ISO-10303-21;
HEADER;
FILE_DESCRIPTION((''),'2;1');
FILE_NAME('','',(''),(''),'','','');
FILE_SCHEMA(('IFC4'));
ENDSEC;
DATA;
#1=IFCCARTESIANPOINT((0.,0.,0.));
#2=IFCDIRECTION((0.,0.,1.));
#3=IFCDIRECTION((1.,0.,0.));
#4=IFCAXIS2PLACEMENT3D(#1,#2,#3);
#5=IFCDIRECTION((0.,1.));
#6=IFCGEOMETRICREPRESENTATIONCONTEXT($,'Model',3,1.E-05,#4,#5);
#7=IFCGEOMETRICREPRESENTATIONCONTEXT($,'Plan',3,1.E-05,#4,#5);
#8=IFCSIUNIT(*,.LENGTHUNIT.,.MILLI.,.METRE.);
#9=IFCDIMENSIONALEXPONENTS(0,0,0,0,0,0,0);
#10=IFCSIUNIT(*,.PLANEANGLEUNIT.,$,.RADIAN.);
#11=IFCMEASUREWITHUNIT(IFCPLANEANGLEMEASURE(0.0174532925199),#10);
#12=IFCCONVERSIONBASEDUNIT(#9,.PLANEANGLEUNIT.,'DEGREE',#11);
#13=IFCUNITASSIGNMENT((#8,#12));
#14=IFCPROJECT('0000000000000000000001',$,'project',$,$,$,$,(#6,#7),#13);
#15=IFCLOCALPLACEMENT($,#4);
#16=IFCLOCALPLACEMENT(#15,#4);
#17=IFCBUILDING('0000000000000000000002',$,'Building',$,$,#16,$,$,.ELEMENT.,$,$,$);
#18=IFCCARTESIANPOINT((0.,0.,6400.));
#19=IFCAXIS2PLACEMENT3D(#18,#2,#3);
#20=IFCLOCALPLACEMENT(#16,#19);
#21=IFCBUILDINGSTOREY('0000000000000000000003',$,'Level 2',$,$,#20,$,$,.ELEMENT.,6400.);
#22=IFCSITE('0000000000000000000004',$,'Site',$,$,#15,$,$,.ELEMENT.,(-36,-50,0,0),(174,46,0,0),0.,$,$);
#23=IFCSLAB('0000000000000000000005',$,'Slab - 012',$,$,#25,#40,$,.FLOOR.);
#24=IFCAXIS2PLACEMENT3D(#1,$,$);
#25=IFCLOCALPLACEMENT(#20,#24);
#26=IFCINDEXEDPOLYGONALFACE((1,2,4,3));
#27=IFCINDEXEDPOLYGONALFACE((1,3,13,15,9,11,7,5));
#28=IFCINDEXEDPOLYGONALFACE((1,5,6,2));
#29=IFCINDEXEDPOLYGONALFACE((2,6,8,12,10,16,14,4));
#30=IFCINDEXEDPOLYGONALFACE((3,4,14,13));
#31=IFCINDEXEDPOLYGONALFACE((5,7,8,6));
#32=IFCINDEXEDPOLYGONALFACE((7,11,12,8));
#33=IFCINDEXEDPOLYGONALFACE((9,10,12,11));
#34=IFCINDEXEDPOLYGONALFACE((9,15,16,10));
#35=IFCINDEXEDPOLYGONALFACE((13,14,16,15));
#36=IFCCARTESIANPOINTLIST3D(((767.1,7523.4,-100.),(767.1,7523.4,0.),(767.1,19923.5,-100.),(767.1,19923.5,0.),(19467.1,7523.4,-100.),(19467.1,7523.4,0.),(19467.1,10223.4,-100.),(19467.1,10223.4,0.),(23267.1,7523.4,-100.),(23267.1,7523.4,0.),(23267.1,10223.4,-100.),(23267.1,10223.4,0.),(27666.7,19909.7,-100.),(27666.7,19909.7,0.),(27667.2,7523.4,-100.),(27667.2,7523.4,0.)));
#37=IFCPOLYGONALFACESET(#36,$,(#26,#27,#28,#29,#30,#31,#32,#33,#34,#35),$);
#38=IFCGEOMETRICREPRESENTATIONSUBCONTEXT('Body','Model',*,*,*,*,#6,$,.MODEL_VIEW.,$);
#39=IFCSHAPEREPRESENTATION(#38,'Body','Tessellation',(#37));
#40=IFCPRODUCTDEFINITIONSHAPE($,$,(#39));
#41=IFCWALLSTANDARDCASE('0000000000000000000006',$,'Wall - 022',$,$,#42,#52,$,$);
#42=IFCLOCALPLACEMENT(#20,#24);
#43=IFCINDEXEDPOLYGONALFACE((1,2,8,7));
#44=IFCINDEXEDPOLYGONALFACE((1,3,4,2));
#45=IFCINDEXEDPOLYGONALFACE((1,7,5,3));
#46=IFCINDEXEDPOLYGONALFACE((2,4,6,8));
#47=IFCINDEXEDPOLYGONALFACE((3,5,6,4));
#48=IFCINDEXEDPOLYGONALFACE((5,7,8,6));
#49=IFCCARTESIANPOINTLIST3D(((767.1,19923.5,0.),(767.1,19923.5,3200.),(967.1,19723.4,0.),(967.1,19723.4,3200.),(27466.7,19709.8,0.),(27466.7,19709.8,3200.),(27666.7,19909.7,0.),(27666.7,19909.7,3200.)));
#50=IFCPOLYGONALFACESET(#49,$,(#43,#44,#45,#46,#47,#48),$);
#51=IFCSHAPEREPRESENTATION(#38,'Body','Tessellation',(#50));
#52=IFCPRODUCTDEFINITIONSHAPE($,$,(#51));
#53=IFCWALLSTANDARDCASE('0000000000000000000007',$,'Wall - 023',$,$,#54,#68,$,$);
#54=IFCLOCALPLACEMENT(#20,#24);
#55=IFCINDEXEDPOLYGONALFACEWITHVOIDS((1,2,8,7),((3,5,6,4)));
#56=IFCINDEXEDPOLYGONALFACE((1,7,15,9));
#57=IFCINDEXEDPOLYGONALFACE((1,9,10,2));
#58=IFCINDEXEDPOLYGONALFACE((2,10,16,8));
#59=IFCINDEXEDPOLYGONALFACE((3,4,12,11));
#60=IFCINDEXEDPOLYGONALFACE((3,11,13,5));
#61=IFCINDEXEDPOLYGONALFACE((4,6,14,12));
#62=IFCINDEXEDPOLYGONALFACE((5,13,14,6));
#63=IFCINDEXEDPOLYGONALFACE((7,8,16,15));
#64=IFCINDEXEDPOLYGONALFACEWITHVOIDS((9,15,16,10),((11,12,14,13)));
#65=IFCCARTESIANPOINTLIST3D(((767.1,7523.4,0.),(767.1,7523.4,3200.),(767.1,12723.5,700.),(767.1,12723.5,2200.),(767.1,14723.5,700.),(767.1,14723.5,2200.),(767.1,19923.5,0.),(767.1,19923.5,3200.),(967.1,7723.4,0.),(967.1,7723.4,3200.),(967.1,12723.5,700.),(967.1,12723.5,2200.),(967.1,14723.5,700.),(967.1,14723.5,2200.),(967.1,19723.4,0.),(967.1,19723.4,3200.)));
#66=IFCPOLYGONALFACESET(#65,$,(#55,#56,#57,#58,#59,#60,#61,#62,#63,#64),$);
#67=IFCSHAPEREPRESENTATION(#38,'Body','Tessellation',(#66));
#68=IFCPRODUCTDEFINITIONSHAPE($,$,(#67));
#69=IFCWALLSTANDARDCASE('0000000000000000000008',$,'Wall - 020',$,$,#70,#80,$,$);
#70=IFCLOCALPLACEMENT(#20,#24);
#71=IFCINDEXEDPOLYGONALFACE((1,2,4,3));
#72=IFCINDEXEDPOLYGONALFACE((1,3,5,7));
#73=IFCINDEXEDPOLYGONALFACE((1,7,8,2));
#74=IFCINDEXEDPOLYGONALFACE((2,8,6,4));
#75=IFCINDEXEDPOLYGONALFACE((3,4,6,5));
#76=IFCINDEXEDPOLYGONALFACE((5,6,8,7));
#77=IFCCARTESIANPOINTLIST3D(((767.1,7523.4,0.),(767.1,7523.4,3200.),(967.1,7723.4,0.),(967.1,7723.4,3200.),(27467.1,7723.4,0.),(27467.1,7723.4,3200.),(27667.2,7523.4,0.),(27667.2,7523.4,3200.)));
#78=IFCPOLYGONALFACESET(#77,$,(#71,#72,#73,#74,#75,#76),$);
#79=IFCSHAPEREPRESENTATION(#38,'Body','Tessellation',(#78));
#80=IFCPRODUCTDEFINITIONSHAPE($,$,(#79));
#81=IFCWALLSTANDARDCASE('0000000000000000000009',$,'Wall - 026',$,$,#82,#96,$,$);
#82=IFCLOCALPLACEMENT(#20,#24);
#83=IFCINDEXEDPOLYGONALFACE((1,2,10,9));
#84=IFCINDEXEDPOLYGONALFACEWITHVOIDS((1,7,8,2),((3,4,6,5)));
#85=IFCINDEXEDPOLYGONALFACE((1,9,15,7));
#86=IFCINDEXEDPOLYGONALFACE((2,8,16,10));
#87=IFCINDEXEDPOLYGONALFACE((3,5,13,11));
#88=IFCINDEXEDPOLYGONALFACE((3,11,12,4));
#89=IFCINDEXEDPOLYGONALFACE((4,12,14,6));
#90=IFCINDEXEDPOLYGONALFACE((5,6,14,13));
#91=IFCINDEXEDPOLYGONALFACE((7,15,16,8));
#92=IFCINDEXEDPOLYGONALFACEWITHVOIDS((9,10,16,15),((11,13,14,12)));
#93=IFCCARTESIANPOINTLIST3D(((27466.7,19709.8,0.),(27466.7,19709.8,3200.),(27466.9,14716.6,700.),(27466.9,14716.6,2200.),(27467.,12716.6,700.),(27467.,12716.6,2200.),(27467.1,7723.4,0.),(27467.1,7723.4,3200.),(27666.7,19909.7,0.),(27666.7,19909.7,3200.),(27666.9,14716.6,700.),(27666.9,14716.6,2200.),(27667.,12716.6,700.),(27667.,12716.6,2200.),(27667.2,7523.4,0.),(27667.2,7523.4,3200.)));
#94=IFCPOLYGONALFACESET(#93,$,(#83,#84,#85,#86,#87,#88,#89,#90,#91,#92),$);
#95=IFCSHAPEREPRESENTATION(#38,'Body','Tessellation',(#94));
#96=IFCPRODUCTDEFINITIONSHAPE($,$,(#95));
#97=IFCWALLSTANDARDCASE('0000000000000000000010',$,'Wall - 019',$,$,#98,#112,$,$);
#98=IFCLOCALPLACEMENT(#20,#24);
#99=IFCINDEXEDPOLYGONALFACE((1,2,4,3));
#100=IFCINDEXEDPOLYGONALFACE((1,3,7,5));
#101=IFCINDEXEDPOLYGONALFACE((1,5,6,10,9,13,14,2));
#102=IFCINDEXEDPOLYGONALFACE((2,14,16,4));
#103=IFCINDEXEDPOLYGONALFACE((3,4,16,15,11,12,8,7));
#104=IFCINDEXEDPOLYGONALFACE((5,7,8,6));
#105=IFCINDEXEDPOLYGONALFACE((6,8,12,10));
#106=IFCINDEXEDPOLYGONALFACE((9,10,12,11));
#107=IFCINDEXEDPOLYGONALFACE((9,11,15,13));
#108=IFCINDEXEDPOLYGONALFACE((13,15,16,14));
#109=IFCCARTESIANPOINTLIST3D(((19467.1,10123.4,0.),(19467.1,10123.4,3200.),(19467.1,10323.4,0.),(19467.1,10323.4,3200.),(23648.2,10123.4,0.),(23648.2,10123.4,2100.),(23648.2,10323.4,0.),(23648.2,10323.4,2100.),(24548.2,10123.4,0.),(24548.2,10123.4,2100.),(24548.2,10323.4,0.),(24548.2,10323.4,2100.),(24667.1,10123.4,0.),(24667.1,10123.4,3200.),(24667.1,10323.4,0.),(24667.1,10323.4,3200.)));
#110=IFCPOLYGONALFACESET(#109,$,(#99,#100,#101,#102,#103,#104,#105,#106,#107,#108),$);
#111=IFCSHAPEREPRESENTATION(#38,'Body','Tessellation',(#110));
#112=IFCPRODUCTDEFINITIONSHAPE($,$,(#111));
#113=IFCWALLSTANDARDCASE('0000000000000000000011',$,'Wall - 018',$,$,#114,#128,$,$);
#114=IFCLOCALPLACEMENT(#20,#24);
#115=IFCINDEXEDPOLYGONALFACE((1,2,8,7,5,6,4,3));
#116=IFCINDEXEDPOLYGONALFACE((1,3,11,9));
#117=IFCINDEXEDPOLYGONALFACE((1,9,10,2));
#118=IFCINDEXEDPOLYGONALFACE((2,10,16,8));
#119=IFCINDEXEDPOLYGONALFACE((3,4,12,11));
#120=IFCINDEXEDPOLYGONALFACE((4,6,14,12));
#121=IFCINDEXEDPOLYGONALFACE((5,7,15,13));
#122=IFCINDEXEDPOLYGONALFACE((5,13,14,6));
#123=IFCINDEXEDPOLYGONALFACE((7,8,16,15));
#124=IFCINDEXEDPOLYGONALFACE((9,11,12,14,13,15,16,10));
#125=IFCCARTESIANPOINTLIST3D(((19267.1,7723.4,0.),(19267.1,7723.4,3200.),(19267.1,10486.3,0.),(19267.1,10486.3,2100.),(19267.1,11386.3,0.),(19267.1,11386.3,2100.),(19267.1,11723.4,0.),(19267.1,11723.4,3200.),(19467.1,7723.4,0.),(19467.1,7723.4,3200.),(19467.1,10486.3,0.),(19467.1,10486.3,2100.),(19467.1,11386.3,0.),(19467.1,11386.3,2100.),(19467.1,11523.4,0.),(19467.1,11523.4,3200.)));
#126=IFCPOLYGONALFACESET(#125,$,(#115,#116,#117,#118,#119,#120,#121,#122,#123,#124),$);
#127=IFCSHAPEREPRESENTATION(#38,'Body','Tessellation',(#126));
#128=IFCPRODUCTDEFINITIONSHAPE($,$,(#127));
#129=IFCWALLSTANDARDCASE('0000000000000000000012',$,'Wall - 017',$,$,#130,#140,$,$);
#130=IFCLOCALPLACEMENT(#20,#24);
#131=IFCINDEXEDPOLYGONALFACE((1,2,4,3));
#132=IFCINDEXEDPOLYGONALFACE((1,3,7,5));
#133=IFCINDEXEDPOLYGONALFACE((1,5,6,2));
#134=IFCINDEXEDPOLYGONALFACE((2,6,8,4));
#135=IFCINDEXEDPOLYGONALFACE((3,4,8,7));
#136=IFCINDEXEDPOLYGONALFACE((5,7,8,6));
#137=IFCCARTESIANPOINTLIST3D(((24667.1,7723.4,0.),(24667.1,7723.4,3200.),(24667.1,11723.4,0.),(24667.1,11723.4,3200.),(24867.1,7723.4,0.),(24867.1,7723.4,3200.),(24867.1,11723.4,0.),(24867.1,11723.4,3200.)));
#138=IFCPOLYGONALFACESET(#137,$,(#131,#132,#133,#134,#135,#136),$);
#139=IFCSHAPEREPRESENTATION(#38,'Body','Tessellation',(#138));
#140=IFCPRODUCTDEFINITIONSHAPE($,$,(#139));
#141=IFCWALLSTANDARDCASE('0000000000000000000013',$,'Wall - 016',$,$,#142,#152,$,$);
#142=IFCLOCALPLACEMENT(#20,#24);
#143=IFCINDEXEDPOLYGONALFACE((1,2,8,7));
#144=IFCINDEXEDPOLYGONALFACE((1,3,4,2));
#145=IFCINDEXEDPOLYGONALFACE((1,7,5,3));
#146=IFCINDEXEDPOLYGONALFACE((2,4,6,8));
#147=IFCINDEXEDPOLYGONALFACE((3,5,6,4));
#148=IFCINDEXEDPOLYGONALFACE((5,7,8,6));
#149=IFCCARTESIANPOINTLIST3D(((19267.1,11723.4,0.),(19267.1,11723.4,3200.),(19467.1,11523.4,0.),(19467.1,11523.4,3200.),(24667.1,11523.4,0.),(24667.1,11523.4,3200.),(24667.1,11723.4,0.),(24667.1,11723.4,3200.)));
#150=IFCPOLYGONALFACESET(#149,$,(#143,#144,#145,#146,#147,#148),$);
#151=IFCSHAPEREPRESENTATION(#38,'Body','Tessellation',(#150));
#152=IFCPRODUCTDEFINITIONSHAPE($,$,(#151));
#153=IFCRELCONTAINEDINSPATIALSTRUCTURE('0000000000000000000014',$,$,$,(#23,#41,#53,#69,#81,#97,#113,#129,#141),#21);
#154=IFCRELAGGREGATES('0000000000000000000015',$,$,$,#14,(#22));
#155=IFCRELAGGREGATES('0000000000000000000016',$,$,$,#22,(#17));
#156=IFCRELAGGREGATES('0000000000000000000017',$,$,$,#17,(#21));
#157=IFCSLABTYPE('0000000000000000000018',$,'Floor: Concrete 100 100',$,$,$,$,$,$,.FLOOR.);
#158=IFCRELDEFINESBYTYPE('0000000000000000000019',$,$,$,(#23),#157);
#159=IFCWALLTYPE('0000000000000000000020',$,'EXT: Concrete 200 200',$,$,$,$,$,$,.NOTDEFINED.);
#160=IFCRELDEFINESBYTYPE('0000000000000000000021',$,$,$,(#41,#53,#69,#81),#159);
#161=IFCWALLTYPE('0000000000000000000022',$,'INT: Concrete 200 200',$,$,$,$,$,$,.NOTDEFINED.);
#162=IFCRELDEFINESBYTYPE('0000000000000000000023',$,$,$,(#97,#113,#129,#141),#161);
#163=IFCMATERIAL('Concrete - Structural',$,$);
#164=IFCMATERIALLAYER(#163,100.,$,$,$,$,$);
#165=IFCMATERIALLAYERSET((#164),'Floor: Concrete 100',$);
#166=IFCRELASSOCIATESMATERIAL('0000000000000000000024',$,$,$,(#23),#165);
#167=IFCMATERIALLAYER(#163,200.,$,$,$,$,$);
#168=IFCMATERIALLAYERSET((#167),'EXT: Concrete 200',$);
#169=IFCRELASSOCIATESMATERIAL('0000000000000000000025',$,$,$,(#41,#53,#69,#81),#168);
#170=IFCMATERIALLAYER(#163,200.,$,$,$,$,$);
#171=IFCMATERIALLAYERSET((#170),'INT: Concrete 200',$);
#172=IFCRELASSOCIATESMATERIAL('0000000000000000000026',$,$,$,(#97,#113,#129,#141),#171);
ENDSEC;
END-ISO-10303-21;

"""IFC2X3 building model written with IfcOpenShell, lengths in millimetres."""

from ifc_helpers import new_model, entity, si_unit, converted_unit, direction, frame, origin_with_axes, origin_2d_with_axis, place, context, subcontext, project, spatial, polyline, rectangle, outline, extrude, material, layer, layer_set, layer_usage, type_object, element, save


model = new_model("IFC2X3")

# Units and contexts
model_context = context("Model", 3, precision=1e-05, world=origin_with_axes(), true_north=direction((0.0, 1.0)))
plan_context = context("Plan", 3, precision=1e-05, world=origin_with_axes(), true_north=direction((0.0, 1.0)))
body_context = subcontext(model_context, "Body", "Model", "MODEL_VIEW")
ifc_project = project(units=[si_unit("LENGTHUNIT", "METRE", prefix="MILLI"), converted_unit("PLANEANGLEUNIT", "DEGREE", entity("IfcPlaneAngleMeasure", 0.0174532925199), si_unit("PLANEANGLEUNIT", "RADIAN"), dimensions=[0, 0, 0, 0, 0, 0, 0])], contexts=[model_context, plan_context])

# Site, building, storey
site_placement = place(None, origin_with_axes())
site = spatial("IfcSite", under=ifc_project, at=site_placement, Name="Site", CompositionType="ELEMENT", RefLatitude=(-36, -50, 0, 0), RefLongitude=(174, 46, 0, 0), RefElevation=0.0)
building_placement = place(site_placement, origin_with_axes())
building = spatial("IfcBuilding", under=site, at=building_placement, Name="Building", CompositionType="ELEMENT")
storey_placement = place(building_placement, frame((0.0, 0.0, 6400.0), z_axis=(0.0, 0.0, 1.0), x_axis=(1.0, 0.0, 0.0)))
storey = spatial("IfcBuildingStorey", under=building, at=storey_placement, Name="Level 2", CompositionType="ELEMENT", Elevation=6400.0)

# Slab
ifc_material = material(Name="Concrete - Structural")
ifc_layer_1 = layer(ifc_material, 100.0)
ifc_layer_set_1 = layer_set([ifc_layer_1], Name="Floor: Concrete 100")
ifc_layer_usage_1 = layer_usage(ifc_layer_set_1, "AXIS3", "NEGATIVE", 100.0)
slab_type = type_object("IfcSlabType", Name="Floor: Concrete 100 100", PredefinedType="FLOOR")
slab_placement = place(storey_placement, frame((767.1, 19923.5, 0.0), z_axis=(0.0, 0.0, 1.0), x_axis=(1.0, 0.0, 0.0)))
element("IfcSlab", 1, at=slab_placement, inside=storey, type_object=slab_type, material=ifc_layer_usage_1, Name="Slab - 012", PredefinedType="FLOOR", context=body_context, shape_type="SweptSolid", body=[
    extrude(outline(polyline([(0.0, 0.0), (0.0, -12400.1), (18700.0, -12400.1), (18700.0, -9700.1), (22500.0, -9700.1), (22500.0, -12400.1), (26900.0, -12400.1), (26899.5, -13.8), (0.0, 0.0)])), frame((0.0, 0.0, -100.0), z_axis=(0.0, 0.0, 1.0), x_axis=(1.0, 0.0, 0.0)), (0.0, 0.0, 1.0), 100.0),
])

# Wall
ifc_layer_2 = layer(ifc_material, 200.0)
ifc_layer_set_2 = layer_set([ifc_layer_2], Name="EXT: Concrete 200")
ifc_layer_usage_2 = layer_usage(ifc_layer_set_2, "AXIS2", "POSITIVE", 0.0)
wall_type_1 = type_object("IfcWallType", Name="EXT: Concrete 200 200", PredefinedType="NOTDEFINED")
wall_1_placement = place(storey_placement, frame((967.1, 19723.4, 0.0), z_axis=(0.0, 0.0, 1.0), x_axis=(1.0, -0.000513, 0.0)))
element("IfcWallStandardCase", 2, at=wall_1_placement, inside=storey, type_object=wall_type_1, material=ifc_layer_usage_2, Name="Wall - 022", context=body_context, shape_type="SweptSolid", body=[
    extrude(outline(polyline([(0.0, 0.0), (26499.5, 0.0), (26699.4, 200.0), (-200.1, 200.0), (0.0, 0.0)])), origin_with_axes(), (0.0, 0.0, 1.0), 3200.0),
])

# Wall, opening
ifc_layer_usage_3 = layer_usage(ifc_layer_set_2, "AXIS2", "POSITIVE", -200.0)
wall_2_placement = place(storey_placement, frame((967.1, 19723.4, 0.0), z_axis=(0.0, 0.0, 1.0), x_axis=(0.0, -1.0, 0.0)))
wall_2 = element("IfcWallStandardCase", 3, at=wall_2_placement, inside=storey, type_object=wall_type_1, material=ifc_layer_usage_3, Name="Wall - 023", context=body_context, shape_type="SweptSolid", body=[
    extrude(outline(polyline([(-200.1, -200.0), (12200.0, -200.0), (12000.0, 0.0), (0.0, 0.0), (-200.1, -200.0)])), origin_with_axes(), (0.0, 0.0, 1.0), 3200.0),
])
opening_1_placement = place(wall_2_placement, frame((5999.9, 0.0, 700.0), z_axis=(0.0, 0.0, 1.0), x_axis=(1.0, 0.0, 0.0)))
element("IfcOpeningElement", 4, at=opening_1_placement, cuts=wall_2, context=body_context, shape_type="SweptSolid", body=[
    extrude(rectangle(XDim=2000.0, YDim=1500.0, at=origin_2d_with_axis()), frame((0.0, 200.0, 750.0), z_axis=(0.0, 1.0, 0.0), x_axis=(1.0, 0.0, 0.0)), (0.0, 0.0, -1.0), 600.0),
])

# Wall
ifc_layer_usage_4 = layer_usage(ifc_layer_set_2, "AXIS2", "POSITIVE", 0.0)
wall_3_placement = place(storey_placement, frame((27667.1, 7723.4, 0.0), z_axis=(0.0, 0.0, 1.0), x_axis=(-1.0, 0.0, 0.0)))
element("IfcWallStandardCase", 5, at=wall_3_placement, inside=storey, type_object=wall_type_1, material=ifc_layer_usage_4, Name="Wall - 020", context=body_context, shape_type="SweptSolid", body=[
    extrude(outline(polyline([(200.0, 0.0), (26700.0, 0.0), (26900.0, 200.0), (0.0, 200.0), (200.0, 0.0)])), origin_with_axes(), (0.0, 0.0, 1.0), 3200.0),
])

# Walls, openings
ifc_layer_usage_5 = layer_usage(ifc_layer_set_2, "AXIS2", "POSITIVE", -200.0)
wall_4_placement = place(storey_placement, frame((27666.7, 19709.7, 0.0), z_axis=(0.0, 0.0, 1.0), x_axis=(0.000039, -1.0, 0.0)))
wall_4 = element("IfcWallStandardCase", 6, at=wall_4_placement, inside=storey, type_object=wall_type_1, material=ifc_layer_usage_5, Name="Wall - 026", context=body_context, shape_type="SweptSolid", body=[
    extrude(outline(polyline([(-0.1, -200.0), (11986.3, -200.0), (12186.3, 0.0), (-200.0, 0.0), (-0.1, -200.0)])), origin_with_axes(), (0.0, 0.0, 1.0), 3200.0),
])
opening_2_placement = place(wall_4_placement, frame((5993.2, 0.0, 700.0), z_axis=(0.0, 0.0, 1.0), x_axis=(1.0, 0.0, 0.0)))
element("IfcOpeningElement", 7, at=opening_2_placement, cuts=wall_4, context=body_context, shape_type="SweptSolid", body=[
    extrude(rectangle(XDim=2000.0, YDim=1500.0, at=origin_2d_with_axis()), frame((0.0, -200.0, 750.0), z_axis=(0.0, -1.0, 0.0), x_axis=(-1.0, 0.0, 0.0)), (0.0, 0.0, -1.0), 600.0),
])
ifc_layer_3 = layer(ifc_material, 200.0)
ifc_layer_set_3 = layer_set([ifc_layer_3], Name="INT: Concrete 200")
ifc_layer_usage_6 = layer_usage(ifc_layer_set_3, "AXIS2", "POSITIVE", -200.0)
wall_type_2 = type_object("IfcWallType", Name="INT: Concrete 200 200", PredefinedType="NOTDEFINED")
wall_5_placement = place(storey_placement, frame((19467.1, 10323.4, 0.0), z_axis=(0.0, 0.0, 1.0), x_axis=(1.0, 0.0, 0.0)))
wall_5 = element("IfcWallStandardCase", 8, at=wall_5_placement, inside=storey, type_object=wall_type_2, material=ifc_layer_usage_6, Name="Wall - 019", context=body_context, shape_type="SweptSolid", body=[
    extrude(outline(polyline([(0.0, -200.0), (5200.0, -200.0), (5200.0, 0.0), (0.0, 0.0), (0.0, -200.0)])), origin_with_axes(), (0.0, 0.0, 1.0), 3200.0),
])
opening_3_placement = place(wall_5_placement, frame((4631.0, 0.0, 0.0), z_axis=(0.0, 0.0, 1.0), x_axis=(1.0, 0.0, 0.0)))
element("IfcOpeningElement", 9, at=opening_3_placement, cuts=wall_5, context=body_context, shape_type="SweptSolid", body=[
    extrude(rectangle(XDim=900.0, YDim=2100.0, at=origin_2d_with_axis()), frame((0.0, 200.0, 1050.0), z_axis=(0.0, 1.0, 0.0), x_axis=(1.0, 0.0, 0.0)), (0.0, 0.0, -1.0), 600.0),
])
ifc_layer_usage_7 = layer_usage(ifc_layer_set_3, "AXIS2", "POSITIVE", -200.0)
wall_6_placement = place(storey_placement, frame((19467.1, 11523.4, 0.0), z_axis=(0.0, 0.0, 1.0), x_axis=(0.0, -1.0, 0.0)))
wall_6 = element("IfcWallStandardCase", 10, at=wall_6_placement, inside=storey, type_object=wall_type_2, material=ifc_layer_usage_7, Name="Wall - 018", context=body_context, shape_type="SweptSolid", body=[
    extrude(outline(polyline([(-200.0, -200.0), (3800.0, -200.0), (3800.0, 0.0), (0.0, 0.0), (-200.0, -200.0)])), origin_with_axes(), (0.0, 0.0, 1.0), 3200.0),
])
opening_4_placement = place(wall_6_placement, frame((587.1, 0.0, 0.0), z_axis=(0.0, 0.0, 1.0), x_axis=(1.0, 0.0, 0.0)))
element("IfcOpeningElement", 11, at=opening_4_placement, cuts=wall_6, context=body_context, shape_type="SweptSolid", body=[
    extrude(rectangle(XDim=900.0, YDim=2100.0, at=origin_2d_with_axis()), frame((0.0, -200.0, 1050.0), z_axis=(0.0, 1.0, 0.0), x_axis=(1.0, 0.0, 0.0)), (0.0, 0.0, 1.0), 600.0),
])

# Walls
ifc_layer_usage_8 = layer_usage(ifc_layer_set_3, "AXIS2", "POSITIVE", 0.0)
wall_7_placement = place(storey_placement, frame((24667.1, 11723.4, 0.0), z_axis=(0.0, 0.0, 1.0), x_axis=(0.0, -1.0, 0.0)))
element("IfcWallStandardCase", 12, at=wall_7_placement, inside=storey, type_object=wall_type_2, material=ifc_layer_usage_8, Name="Wall - 017", context=body_context, shape_type="SweptSolid", body=[
    extrude(outline(polyline([(0.0, 0.0), (4000.0, 0.0), (4000.0, 200.0), (0.0, 200.0), (0.0, 0.0)])), origin_with_axes(), (0.0, 0.0, 1.0), 3200.0),
])
ifc_layer_usage_9 = layer_usage(ifc_layer_set_3, "AXIS2", "POSITIVE", 0.0)
wall_8_placement = place(storey_placement, frame((19467.1, 11523.4, 0.0), z_axis=(0.0, 0.0, 1.0), x_axis=(1.0, 0.0, 0.0)))
element("IfcWallStandardCase", 13, at=wall_8_placement, inside=storey, type_object=wall_type_2, material=ifc_layer_usage_9, Name="Wall - 016", context=body_context, shape_type="SweptSolid", body=[
    extrude(outline(polyline([(0.0, 0.0), (5200.0, 0.0), (5200.0, 200.0), (-200.0, 200.0), (0.0, 0.0)])), origin_with_axes(), (0.0, 0.0, 1.0), 3200.0),
])

save(model, "model.ifc")
